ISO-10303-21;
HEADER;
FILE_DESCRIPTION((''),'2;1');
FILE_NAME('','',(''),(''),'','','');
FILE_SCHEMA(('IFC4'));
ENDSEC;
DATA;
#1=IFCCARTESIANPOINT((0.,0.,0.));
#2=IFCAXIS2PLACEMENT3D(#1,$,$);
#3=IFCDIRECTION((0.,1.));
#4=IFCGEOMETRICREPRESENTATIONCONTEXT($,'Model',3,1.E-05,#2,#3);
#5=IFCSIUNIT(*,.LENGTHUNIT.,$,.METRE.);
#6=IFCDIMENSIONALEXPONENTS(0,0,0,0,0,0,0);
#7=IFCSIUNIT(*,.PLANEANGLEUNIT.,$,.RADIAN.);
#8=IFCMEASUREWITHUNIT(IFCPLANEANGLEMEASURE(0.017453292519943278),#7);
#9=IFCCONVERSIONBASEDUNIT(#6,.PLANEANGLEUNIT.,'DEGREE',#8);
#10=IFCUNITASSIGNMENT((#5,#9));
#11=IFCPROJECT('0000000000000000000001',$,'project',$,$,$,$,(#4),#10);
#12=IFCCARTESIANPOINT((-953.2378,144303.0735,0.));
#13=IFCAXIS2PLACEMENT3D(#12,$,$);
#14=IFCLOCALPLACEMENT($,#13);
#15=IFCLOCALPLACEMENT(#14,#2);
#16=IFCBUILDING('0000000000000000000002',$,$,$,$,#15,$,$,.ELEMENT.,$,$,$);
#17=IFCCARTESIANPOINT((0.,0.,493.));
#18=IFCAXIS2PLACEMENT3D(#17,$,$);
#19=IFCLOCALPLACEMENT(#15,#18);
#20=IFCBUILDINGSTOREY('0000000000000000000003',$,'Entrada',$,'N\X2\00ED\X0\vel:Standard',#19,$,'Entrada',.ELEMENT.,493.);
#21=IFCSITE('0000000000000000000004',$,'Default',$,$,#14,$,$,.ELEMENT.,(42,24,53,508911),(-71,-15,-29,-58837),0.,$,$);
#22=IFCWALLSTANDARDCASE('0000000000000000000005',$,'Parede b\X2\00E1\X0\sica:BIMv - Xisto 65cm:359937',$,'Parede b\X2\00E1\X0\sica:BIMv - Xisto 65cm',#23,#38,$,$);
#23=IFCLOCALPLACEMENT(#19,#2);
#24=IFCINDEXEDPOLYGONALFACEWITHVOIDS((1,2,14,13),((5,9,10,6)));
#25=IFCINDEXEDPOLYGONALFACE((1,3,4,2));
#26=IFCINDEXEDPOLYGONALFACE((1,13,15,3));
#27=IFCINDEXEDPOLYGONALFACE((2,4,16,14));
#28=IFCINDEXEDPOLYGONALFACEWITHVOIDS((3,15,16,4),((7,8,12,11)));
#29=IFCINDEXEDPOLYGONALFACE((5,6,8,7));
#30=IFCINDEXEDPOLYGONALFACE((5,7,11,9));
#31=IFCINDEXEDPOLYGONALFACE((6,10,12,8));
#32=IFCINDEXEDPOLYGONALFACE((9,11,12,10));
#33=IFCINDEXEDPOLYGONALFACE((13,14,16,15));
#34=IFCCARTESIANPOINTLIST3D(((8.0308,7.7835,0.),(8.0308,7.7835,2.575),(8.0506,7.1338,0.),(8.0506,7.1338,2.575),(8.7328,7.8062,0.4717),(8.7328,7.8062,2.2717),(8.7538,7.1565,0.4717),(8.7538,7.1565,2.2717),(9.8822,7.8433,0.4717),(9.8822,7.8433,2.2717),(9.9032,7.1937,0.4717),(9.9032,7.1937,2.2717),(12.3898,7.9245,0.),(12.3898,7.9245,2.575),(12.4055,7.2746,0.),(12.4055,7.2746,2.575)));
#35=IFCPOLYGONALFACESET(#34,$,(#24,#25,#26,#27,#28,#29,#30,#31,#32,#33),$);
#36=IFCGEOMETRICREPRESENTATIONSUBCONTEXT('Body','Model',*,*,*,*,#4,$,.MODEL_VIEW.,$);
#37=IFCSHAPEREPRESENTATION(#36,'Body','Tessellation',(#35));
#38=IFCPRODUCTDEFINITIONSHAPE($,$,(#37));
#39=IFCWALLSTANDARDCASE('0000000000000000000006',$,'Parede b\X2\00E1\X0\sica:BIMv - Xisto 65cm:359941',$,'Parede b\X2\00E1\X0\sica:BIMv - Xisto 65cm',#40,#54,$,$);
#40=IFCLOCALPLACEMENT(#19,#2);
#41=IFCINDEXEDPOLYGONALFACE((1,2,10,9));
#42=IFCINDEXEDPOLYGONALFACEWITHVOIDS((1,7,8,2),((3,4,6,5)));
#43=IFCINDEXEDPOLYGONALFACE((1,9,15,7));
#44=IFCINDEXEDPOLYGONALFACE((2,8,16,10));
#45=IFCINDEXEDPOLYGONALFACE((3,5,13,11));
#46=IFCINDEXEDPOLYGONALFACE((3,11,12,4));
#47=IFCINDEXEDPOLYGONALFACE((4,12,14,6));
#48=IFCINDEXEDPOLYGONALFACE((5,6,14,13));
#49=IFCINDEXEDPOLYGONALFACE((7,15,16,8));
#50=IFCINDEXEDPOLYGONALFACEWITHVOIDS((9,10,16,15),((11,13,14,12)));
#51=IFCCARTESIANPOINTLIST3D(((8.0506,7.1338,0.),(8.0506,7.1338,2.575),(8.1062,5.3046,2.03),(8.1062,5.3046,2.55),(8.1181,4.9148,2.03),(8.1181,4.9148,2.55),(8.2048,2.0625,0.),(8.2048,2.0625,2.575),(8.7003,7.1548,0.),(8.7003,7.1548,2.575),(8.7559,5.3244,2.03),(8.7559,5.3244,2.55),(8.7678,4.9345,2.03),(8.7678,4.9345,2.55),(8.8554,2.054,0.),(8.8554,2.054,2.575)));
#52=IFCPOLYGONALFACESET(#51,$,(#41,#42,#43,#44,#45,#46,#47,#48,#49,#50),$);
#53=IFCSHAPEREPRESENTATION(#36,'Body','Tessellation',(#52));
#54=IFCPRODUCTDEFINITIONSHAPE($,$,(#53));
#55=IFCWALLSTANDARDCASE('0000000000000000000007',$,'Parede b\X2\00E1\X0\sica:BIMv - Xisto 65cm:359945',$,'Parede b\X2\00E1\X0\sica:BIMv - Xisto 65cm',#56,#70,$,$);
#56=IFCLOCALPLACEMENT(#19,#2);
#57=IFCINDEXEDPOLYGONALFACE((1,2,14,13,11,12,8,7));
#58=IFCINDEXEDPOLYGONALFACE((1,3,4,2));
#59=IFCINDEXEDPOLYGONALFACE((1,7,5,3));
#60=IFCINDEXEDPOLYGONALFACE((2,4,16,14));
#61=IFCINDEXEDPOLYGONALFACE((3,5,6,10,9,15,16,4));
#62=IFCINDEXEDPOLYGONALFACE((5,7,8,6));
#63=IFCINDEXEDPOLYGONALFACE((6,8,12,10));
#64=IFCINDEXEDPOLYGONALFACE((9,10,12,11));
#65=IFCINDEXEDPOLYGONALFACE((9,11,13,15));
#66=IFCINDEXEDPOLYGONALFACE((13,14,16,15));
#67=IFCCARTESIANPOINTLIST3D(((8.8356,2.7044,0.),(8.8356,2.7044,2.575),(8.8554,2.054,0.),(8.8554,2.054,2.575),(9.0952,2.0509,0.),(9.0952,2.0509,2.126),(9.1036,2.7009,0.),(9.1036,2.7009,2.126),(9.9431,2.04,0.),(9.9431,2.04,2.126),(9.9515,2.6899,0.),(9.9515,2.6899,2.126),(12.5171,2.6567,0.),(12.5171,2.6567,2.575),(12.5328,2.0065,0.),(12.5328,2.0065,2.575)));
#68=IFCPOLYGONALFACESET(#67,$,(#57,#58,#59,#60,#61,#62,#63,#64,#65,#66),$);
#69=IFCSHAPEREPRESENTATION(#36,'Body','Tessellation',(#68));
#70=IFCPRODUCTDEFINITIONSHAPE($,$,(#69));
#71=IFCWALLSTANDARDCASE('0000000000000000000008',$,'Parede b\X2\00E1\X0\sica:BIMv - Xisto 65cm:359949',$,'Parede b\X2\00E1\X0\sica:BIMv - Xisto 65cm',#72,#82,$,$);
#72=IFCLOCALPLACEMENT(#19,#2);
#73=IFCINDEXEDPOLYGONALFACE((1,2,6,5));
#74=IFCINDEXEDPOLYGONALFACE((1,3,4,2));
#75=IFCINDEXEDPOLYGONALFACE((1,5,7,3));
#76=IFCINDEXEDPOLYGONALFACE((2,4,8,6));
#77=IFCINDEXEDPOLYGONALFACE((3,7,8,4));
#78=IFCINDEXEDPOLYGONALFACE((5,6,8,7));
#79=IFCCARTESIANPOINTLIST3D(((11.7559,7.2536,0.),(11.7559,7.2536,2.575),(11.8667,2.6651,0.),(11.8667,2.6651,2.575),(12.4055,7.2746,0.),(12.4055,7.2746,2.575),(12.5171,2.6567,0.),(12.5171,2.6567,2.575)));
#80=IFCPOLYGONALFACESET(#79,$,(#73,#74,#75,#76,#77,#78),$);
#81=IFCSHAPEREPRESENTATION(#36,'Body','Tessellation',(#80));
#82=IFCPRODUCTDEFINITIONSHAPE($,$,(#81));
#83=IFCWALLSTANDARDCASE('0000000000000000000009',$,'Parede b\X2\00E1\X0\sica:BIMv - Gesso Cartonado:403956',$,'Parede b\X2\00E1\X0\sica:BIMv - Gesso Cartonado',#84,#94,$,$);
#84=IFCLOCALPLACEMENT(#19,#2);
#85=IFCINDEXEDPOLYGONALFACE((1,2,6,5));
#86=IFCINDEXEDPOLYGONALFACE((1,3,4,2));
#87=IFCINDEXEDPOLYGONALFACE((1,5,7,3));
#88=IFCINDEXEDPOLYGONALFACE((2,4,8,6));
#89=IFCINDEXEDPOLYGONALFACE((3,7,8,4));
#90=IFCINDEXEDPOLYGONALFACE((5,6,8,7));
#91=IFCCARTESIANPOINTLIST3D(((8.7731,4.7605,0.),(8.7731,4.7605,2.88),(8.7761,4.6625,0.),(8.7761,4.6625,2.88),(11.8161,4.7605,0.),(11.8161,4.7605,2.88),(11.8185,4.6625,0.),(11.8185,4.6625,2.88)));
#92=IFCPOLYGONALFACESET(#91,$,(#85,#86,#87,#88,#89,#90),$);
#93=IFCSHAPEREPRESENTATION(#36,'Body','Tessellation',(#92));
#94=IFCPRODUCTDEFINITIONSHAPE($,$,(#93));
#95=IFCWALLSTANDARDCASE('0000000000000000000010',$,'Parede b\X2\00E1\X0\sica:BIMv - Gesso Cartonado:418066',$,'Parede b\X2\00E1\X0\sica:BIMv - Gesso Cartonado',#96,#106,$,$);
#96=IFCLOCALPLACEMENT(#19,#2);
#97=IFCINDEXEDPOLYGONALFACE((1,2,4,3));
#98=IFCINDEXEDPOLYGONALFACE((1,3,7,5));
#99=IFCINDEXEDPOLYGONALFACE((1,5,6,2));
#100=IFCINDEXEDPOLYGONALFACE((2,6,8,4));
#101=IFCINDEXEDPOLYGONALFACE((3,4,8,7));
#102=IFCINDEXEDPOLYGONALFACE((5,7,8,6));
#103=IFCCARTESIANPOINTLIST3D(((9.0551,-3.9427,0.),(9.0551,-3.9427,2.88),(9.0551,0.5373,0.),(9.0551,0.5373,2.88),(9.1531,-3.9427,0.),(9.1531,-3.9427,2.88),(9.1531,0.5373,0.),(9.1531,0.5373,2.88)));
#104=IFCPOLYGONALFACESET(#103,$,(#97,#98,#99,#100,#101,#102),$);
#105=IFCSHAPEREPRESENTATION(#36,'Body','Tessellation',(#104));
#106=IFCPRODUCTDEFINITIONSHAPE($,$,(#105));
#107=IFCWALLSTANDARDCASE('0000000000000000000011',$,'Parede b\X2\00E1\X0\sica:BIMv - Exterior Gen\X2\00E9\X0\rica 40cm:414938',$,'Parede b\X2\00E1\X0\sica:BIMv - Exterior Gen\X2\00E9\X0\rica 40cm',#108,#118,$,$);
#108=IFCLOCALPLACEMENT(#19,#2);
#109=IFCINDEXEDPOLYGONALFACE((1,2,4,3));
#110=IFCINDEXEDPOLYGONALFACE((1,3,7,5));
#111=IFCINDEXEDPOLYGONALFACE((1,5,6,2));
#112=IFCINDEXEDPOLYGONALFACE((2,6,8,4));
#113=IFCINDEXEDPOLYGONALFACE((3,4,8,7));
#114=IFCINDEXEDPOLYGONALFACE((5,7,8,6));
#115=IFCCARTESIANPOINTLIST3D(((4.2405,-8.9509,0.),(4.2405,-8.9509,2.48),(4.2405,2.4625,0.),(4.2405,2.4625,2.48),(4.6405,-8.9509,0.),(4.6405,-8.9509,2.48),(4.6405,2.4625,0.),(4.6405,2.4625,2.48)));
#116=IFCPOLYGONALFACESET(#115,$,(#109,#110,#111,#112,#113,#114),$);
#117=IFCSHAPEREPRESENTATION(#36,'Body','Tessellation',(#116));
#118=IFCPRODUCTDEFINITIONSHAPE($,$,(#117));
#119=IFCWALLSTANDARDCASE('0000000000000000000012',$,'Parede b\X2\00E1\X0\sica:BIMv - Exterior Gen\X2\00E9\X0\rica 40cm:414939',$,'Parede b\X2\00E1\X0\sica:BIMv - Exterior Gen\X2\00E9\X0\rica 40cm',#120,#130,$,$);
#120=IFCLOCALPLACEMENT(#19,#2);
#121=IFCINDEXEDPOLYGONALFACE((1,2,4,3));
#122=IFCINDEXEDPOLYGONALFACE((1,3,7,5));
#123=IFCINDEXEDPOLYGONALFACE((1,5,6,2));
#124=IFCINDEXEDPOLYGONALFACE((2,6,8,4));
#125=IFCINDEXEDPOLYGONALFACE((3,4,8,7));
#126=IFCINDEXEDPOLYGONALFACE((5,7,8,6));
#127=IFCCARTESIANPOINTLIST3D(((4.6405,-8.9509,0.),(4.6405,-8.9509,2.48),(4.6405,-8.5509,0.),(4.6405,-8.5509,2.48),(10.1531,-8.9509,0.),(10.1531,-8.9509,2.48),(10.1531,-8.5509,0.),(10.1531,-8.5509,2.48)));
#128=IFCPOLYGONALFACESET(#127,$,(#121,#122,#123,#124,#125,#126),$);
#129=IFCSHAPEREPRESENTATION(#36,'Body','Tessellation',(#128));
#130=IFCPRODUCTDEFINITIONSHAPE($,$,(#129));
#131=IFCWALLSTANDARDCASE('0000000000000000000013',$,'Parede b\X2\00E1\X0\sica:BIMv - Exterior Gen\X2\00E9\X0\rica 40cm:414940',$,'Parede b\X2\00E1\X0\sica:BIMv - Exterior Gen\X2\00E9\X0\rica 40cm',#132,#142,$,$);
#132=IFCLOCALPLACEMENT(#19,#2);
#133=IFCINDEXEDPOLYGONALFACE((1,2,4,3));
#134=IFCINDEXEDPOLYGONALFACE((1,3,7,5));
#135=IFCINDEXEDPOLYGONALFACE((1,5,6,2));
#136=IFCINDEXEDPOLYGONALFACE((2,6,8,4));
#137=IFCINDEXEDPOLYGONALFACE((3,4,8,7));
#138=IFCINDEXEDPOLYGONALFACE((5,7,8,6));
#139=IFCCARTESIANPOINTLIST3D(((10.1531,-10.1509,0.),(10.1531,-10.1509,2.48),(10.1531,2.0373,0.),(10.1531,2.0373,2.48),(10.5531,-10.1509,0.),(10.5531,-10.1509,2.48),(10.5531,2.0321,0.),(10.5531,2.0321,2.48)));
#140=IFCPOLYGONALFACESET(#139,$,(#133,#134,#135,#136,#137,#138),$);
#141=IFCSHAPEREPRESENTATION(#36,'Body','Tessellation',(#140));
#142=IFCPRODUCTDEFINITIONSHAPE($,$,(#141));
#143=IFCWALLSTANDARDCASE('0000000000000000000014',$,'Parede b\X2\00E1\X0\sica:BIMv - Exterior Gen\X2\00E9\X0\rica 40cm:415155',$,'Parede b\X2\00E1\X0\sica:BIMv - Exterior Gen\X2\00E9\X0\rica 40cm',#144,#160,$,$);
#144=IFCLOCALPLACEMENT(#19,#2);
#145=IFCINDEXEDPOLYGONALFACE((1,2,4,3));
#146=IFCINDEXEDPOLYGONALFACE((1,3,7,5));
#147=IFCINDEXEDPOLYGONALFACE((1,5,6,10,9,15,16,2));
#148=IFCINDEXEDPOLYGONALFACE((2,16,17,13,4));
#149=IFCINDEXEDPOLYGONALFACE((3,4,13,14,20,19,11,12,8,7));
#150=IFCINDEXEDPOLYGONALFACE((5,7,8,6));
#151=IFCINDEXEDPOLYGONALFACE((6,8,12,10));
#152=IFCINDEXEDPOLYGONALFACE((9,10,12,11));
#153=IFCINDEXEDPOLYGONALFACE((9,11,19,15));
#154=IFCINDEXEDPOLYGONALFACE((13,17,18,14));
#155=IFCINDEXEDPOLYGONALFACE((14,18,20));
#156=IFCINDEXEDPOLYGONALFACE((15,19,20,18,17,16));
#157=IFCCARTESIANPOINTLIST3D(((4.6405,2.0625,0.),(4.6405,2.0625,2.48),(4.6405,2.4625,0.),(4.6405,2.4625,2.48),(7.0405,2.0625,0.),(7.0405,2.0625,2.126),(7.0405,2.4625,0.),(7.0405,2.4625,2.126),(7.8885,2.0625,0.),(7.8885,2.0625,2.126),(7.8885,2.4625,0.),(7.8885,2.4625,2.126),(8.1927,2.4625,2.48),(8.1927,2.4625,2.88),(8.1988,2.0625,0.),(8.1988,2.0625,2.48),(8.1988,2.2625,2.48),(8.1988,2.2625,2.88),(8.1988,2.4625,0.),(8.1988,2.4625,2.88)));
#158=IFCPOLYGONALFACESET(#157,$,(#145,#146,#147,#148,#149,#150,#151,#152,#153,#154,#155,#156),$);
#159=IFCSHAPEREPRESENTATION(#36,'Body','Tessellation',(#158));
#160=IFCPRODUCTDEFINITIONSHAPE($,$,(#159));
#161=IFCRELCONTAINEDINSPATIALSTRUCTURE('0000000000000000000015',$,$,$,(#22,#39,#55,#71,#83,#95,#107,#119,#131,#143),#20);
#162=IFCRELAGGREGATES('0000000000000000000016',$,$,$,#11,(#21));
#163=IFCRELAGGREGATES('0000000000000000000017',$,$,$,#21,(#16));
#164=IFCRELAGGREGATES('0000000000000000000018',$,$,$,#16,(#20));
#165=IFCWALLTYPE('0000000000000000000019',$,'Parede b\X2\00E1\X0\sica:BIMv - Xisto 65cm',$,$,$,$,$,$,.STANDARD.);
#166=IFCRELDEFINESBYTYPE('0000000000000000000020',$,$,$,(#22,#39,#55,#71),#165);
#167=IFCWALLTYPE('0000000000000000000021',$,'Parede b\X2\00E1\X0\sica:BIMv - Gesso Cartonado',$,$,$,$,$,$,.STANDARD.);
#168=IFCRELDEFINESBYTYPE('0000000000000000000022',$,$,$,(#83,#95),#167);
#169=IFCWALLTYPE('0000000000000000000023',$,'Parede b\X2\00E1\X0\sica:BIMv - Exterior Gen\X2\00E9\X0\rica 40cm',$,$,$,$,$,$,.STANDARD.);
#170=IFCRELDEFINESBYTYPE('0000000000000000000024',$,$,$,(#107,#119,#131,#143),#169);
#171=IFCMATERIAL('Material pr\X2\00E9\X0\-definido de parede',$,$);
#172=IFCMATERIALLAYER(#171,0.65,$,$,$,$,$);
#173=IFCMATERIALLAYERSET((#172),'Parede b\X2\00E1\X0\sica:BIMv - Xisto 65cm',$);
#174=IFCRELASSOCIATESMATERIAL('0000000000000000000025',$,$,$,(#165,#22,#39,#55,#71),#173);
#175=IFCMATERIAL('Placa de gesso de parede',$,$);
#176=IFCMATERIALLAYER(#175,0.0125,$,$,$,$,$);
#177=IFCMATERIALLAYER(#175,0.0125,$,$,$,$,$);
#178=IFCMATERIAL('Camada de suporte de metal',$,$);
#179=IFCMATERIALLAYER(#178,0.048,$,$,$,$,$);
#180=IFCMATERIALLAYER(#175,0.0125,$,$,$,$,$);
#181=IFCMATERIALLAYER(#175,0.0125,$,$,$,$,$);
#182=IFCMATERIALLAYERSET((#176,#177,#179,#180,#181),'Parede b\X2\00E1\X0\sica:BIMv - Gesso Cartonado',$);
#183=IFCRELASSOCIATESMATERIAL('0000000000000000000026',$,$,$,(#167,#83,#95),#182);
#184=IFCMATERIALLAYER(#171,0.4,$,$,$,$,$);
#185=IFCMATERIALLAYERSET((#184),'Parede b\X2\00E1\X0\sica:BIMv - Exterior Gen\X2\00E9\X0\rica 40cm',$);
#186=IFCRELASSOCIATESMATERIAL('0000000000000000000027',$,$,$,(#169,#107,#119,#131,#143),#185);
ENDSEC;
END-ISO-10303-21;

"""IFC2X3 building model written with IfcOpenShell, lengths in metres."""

from ifc_helpers import new_model, entity, si_unit, converted_unit, direction, frame, frame_2d, origin, place, context, subcontext, project, spatial, polyline, rectangle, outline, extrude, clip, bounded_halfspace, material, layer, layer_set, layer_usage, type_object, element, save


model = new_model("IFC2X3")

# Units and contexts
model_context = context("Model", 3, precision=1e-05, world=origin(), true_north=direction((0.0, 1.0)))
body_context = subcontext(model_context, "Body", "Model", "MODEL_VIEW")
ifc_project = project(units=[si_unit("LENGTHUNIT", "METRE"), converted_unit("PLANEANGLEUNIT", "DEGREE", entity("IfcPlaneAngleMeasure", 0.017453292519943278), si_unit("PLANEANGLEUNIT", "RADIAN"), dimensions=[0, 0, 0, 0, 0, 0, 0])], contexts=[model_context])

# Site, building, storey
site_placement = place(None, frame((-953.2378, 144303.0735, 0.0)))
site = spatial("IfcSite", under=ifc_project, at=site_placement, Name="Default", CompositionType="ELEMENT", RefLatitude=(42, 24, 53, 508911), RefLongitude=(-71, -15, -29, -58837), RefElevation=0.0)
building_placement = place(site_placement, origin())
building = spatial("IfcBuilding", under=site, at=building_placement, CompositionType="ELEMENT")
storey_placement = place(building_placement, frame((0.0, 0.0, 493.0)))
storey = spatial("IfcBuildingStorey", under=building, at=storey_placement, Name="Entrada", ObjectType="Nível:Standard", LongName="Entrada", CompositionType="ELEMENT", Elevation=493.0)

# Walls, openings
ifc_material_1 = material(Name="Material pré-definido de parede")
ifc_layer_1 = layer(ifc_material_1, 0.65)
ifc_layer_set_1 = layer_set([ifc_layer_1], Name="Parede básica:BIMv - Xisto 65cm")
ifc_layer_usage_1 = layer_usage(ifc_layer_set_1, "AXIS2", "NEGATIVE", 0.325)
wall_type_1 = type_object("IfcWallType", Name="Parede básica:BIMv - Xisto 65cm", PredefinedType="STANDARD", material=ifc_layer_set_1)
wall_1_placement = place(storey_placement, frame((8.0401, 7.4586, 0.0), z_axis=(0.0, 0.0, 1.0), x_axis=(0.999477, 0.03233, 0.0)))
wall_1 = element("IfcWallStandardCase", 1, at=wall_1_placement, inside=storey, type_object=wall_type_1, material=ifc_layer_usage_1, Name="Parede básica:BIMv - Xisto 65cm:359937", ObjectType="Parede básica:BIMv - Xisto 65cm", context=body_context, shape_type="SweptSolid", body=[
    extrude(outline(polyline([(4.3572, -0.325), (4.3625, 0.325), (0.0013, 0.325), (0.0, -0.325), (0.65, -0.325), (3.7072, -0.325), (4.3572, -0.325)])), origin(), (0.0, 0.0, 1.0), 2.575),
])
opening_1_placement = place(wall_1_placement, frame((-8.277, -7.1948, 0.0), z_axis=(0.0, 0.0, 1.0), x_axis=(0.999477, -0.03233, 0.0)))
element("IfcOpeningElement", 2, at=opening_1_placement, cuts=wall_1, ObjectType="Opening", context=body_context, shape_type="SweptSolid", body=[
    extrude(rectangle(XDim=1.8, YDim=1.15, at=frame_2d((0.0, 0.0), x_axis=(0.0, 1.0))), frame((9.3778, 5.6519, 1.3717), z_axis=(-0.03233, 0.999477, 0.0), x_axis=(-0.999477, -0.03233, 0.0)), (0.0, 0.0, 1.0), 3.048),
])
ifc_layer_usage_2 = layer_usage(ifc_layer_set_1, "AXIS2", "NEGATIVE", 0.325)
wall_2_placement = place(storey_placement, frame((8.5305, 2.0442, 0.0), z_axis=(0.0, 0.0, 1.0), x_axis=(-0.030399, 0.999538, 0.0)))
wall_2 = element("IfcWallStandardCase", 3, at=wall_2_placement, inside=storey, type_object=wall_type_1, material=ifc_layer_usage_2, Name="Parede básica:BIMv - Xisto 65cm:359941", ObjectType="Parede básica:BIMv - Xisto 65cm", context=body_context, shape_type="SweptSolid", body=[
    extrude(outline(polyline([(5.1031, -0.325), (5.1018, 0.325), (0.0282, 0.325), (0.0, -0.325), (0.6506, -0.325), (5.1031, -0.325)])), origin(), (0.0, 0.0, 1.0), 2.575),
])
opening_2_placement = place(wall_2_placement, frame((-1.7839, 8.5887, 0.0), z_axis=(0.0, 0.0, 1.0), x_axis=(-0.030399, -0.999538, 0.0)))
element("IfcOpeningElement", 4, at=opening_2_placement, cuts=wall_2, ObjectType="Opening", context=body_context, shape_type="SweptSolid", body=[
    extrude(rectangle(XDim=0.52, YDim=0.39, at=frame_2d((0.0, 0.0), x_axis=(1.0, 0.0))), frame((10.2852, 5.1758, 2.29), z_axis=(-0.999538, -0.030399, 0.0), x_axis=(0.0, 0.0, 1.0)), (0.0, 0.0, 1.0), 3.048),
])
ifc_layer_usage_3 = layer_usage(ifc_layer_set_1, "AXIS2", "NEGATIVE", 0.325)
wall_3_placement = place(storey_placement, frame((12.537, 2.3314, 0.0), z_axis=(0.0, 0.0, 1.0), x_axis=(-0.999916, 0.012938, 0.0)))
wall_3 = element("IfcWallStandardCase", 5, at=wall_3_placement, inside=storey, type_object=wall_type_1, material=ifc_layer_usage_3, Name="Parede básica:BIMv - Xisto 65cm:359945", ObjectType="Parede básica:BIMv - Xisto 65cm", context=body_context, shape_type="SweptSolid", body=[
    extrude(outline(polyline([(0.0241, -0.325), (0.6746, -0.325), (2.2584, -0.325), (3.7059, -0.325), (3.6778, 0.325), (2.2584, 0.325), (0.0, 0.325), (0.0241, -0.325)])), origin(), (0.0, 0.0, 1.0), 2.575),
])
opening_3_placement = place(wall_3_placement, frame((3.4379, 0.325, 0.0)))
element("IfcOpeningElement", 6, at=opening_3_placement, cuts=wall_3, ObjectType="Opening", context=body_context, shape_type="SweptSolid", body=[
    extrude(rectangle(XDim=2.126, YDim=0.848, at=frame_2d((1.063, 0.424), x_axis=(1.0, 0.0))), frame((0.0, 0.0, 0.0), z_axis=(0.0, -1.0, 0.0), x_axis=(0.0, 0.0, 1.0)), (0.0, 0.0, 1.0), 0.65),
])

# Walls
ifc_layer_usage_4 = layer_usage(ifc_layer_set_1, "AXIS2", "NEGATIVE", 0.325)
wall_4_placement = place(storey_placement, frame((12.0806, 7.2668, 0.0), z_axis=(0.0, 0.0, 1.0), x_axis=(0.024156, -0.999708, 0.0)))
element("IfcWallStandardCase", 7, at=wall_4_placement, inside=storey, type_object=wall_type_1, material=ifc_layer_usage_4, Name="Parede básica:BIMv - Xisto 65cm:359949", ObjectType="Parede básica:BIMv - Xisto 65cm", context=body_context, shape_type="SweptSolid", body=[
    extrude(outline(polyline([(4.5951, -0.325), (4.6193, 0.325), (0.0, 0.325), (0.0053, -0.325), (4.5951, -0.325)])), origin(), (0.0, 0.0, 1.0), 2.575),
])
ifc_material_2 = material(Name="Placa de gesso de parede")
ifc_layer_2 = layer(ifc_material_2, 0.0125)
ifc_layer_3 = layer(ifc_material_2, 0.0125)
ifc_material_3 = material(Name="Camada de suporte de metal")
ifc_layer_4 = layer(ifc_material_3, 0.048)
ifc_layer_5 = layer(ifc_material_2, 0.0125)
ifc_layer_6 = layer(ifc_material_2, 0.0125)
ifc_layer_set_2 = layer_set([ifc_layer_2, ifc_layer_3, ifc_layer_4, ifc_layer_5, ifc_layer_6], Name="Parede básica:BIMv - Gesso Cartonado")
ifc_layer_usage_5 = layer_usage(ifc_layer_set_2, "AXIS2", "NEGATIVE", 0.049)
wall_type_2 = type_object("IfcWallType", Name="Parede básica:BIMv - Gesso Cartonado", PredefinedType="STANDARD", material=ifc_layer_set_2)
wall_5_placement = place(storey_placement, frame((8.7731, 4.7115, 0.0)))
element("IfcWallStandardCase", 8, at=wall_5_placement, inside=storey, type_object=wall_type_2, material=ifc_layer_usage_5, Name="Parede básica:BIMv - Gesso Cartonado:403956", ObjectType="Parede básica:BIMv - Gesso Cartonado", context=body_context, shape_type="SweptSolid", body=[
    extrude(outline(polyline([(3.0454, -0.049), (3.043, 0.049), (0.0, 0.049), (0.003, -0.049), (3.0454, -0.049)])), origin(), (0.0, 0.0, 1.0), 2.88),
])
ifc_layer_usage_6 = layer_usage(ifc_layer_set_2, "AXIS2", "NEGATIVE", 0.049)
wall_6_placement = place(storey_placement, frame((9.1041, -3.9427, 0.0), z_axis=(0.0, 0.0, 1.0), x_axis=(0.0, 1.0, 0.0)))
element("IfcWallStandardCase", 9, at=wall_6_placement, inside=storey, type_object=wall_type_2, material=ifc_layer_usage_6, Name="Parede básica:BIMv - Gesso Cartonado:418066", ObjectType="Parede básica:BIMv - Gesso Cartonado", context=body_context, shape_type="SweptSolid", body=[
    extrude(rectangle(XDim=4.48, YDim=0.098, at=frame_2d((2.24, 0.0), x_axis=(-1.0, 0.0))), origin(), (0.0, 0.0, 1.0), 2.88),
])
ifc_layer_7 = layer(ifc_material_1, 0.4)
ifc_layer_set_3 = layer_set([ifc_layer_7], Name="Parede básica:BIMv - Exterior Genérica 40cm")
ifc_layer_usage_7 = layer_usage(ifc_layer_set_3, "AXIS2", "NEGATIVE", 0.2)
wall_type_3 = type_object("IfcWallType", Name="Parede básica:BIMv - Exterior Genérica 40cm", PredefinedType="STANDARD", material=ifc_layer_set_3)
wall_7_placement = place(storey_placement, frame((4.4405, 2.4625, 0.0), z_axis=(0.0, 0.0, 1.0), x_axis=(0.0, -1.0, 0.0)))
element("IfcWallStandardCase", 10, at=wall_7_placement, inside=storey, type_object=wall_type_3, material=ifc_layer_usage_7, Name="Parede básica:BIMv - Exterior Genérica 40cm:414938", ObjectType="Parede básica:BIMv - Exterior Genérica 40cm", context=body_context, shape_type="Clipping", body=[
    clip(extrude(rectangle(XDim=11.4134, YDim=0.4, at=frame_2d((5.7067, 0.0), x_axis=(-1.0, 0.0))), origin(), (0.0, 0.0, 1.0), 2.48), bounded_halfspace(frame((0.0, -0.2, 2.48), z_axis=(0.0, 0.0, -1.0), x_axis=(0.999538, 0.030399, 0.0)), True, frame((0.0, -0.2, 2.48)), polyline([(0.0, 0.0), (11.4134, 0.0), (11.4134, 0.4), (11.0134, 0.4), (0.4, 0.4), (0.0, 0.4), (0.0, 0.0)]))),
])
ifc_layer_usage_8 = layer_usage(ifc_layer_set_3, "AXIS2", "NEGATIVE", 0.2)
wall_8_placement = place(storey_placement, frame((4.6405, -8.7509, 0.0)))
element("IfcWallStandardCase", 11, at=wall_8_placement, inside=storey, type_object=wall_type_3, material=ifc_layer_usage_8, Name="Parede básica:BIMv - Exterior Genérica 40cm:414939", ObjectType="Parede básica:BIMv - Exterior Genérica 40cm", context=body_context, shape_type="Clipping", body=[
    clip(extrude(rectangle(XDim=5.5127, YDim=0.4, at=frame_2d((2.7563, 0.0), x_axis=(-1.0, 0.0))), origin(), (0.0, 0.0, 1.0), 2.48), bounded_halfspace(frame((0.0, -0.2, 2.48), z_axis=(0.0, 0.0, -1.0), x_axis=(0.030399, -0.999538, 0.0)), True, frame((0.0, -0.2, 2.48)), polyline([(0.0, 0.0), (5.5127, 0.0), (5.5127, 0.4), (0.0, 0.4), (0.0, 0.0)]))),
])
ifc_layer_usage_9 = layer_usage(ifc_layer_set_3, "AXIS2", "POSITIVE", -0.2)
wall_9_placement = place(storey_placement, frame((10.3531, -10.1509, 0.0), z_axis=(0.0, 0.0, 1.0), x_axis=(0.0, 1.0, 0.0)))
element("IfcWallStandardCase", 12, at=wall_9_placement, inside=storey, type_object=wall_type_3, material=ifc_layer_usage_9, Name="Parede básica:BIMv - Exterior Genérica 40cm:414940", ObjectType="Parede básica:BIMv - Exterior Genérica 40cm", context=body_context, shape_type="Clipping", body=[
    clip(extrude(outline(polyline([(12.183, -0.2), (12.1882, 0.2), (1.6, 0.2), (1.2, 0.2), (0.0, 0.2), (0.0, -0.2), (12.183, -0.2)])), origin(), (0.0, 0.0, 1.0), 2.48), bounded_halfspace(frame((0.0, -0.2, 2.48), z_axis=(0.0, 0.0, -1.0), x_axis=(-0.999538, -0.030399, 0.0)), True, frame((0.0, -0.2, 2.48)), polyline([(0.0, 0.0), (12.183, 0.0), (12.1882, 0.4), (10.6882, 0.4), (6.2082, 0.4), (1.6, 0.4), (1.2, 0.4), (0.0, 0.4), (0.0, 0.0)]))),
])

# Wall, opening
ifc_layer_usage_10 = layer_usage(ifc_layer_set_3, "AXIS2", "POSITIVE", -0.2)
wall_10_placement = place(storey_placement, frame((8.1988, 2.2625, 0.0), z_axis=(0.0, 0.0, 1.0), x_axis=(-1.0, 0.0, 0.0)))
wall_10 = element("IfcWallStandardCase", 13, at=wall_10_placement, inside=storey, type_object=wall_type_3, material=ifc_layer_usage_10, Name="Parede básica:BIMv - Exterior Genérica 40cm:415155", ObjectType="Parede básica:BIMv - Exterior Genérica 40cm", context=body_context, shape_type="Clipping", body=[
    clip(extrude(rectangle(XDim=3.5583, YDim=0.4, at=frame_2d((1.7791, 0.0), x_axis=(-1.0, 0.0))), origin(), (0.0, 0.0, 1.0), 2.88), bounded_halfspace(frame((0.0061, -0.2, 2.48), z_axis=(0.0, 0.0, -1.0), x_axis=(-0.030399, 0.999538, 0.0)), True, frame((0.0061, -0.2, 2.48)), polyline([(0.0, 0.0), (3.5522, 0.0), (3.5522, 0.4), (-0.0061, 0.4), (-0.0061, 0.2), (0.0, 0.0)]))),
])
opening_4_placement = place(wall_10_placement, frame((0.3103, -0.2, 0.0)))
element("IfcOpeningElement", 14, at=opening_4_placement, cuts=wall_10, ObjectType="Opening", context=body_context, shape_type="SweptSolid", body=[
    extrude(rectangle(XDim=2.126, YDim=0.848, at=frame_2d((1.063, 0.424), x_axis=(1.0, 0.0))), frame((0.0, 0.0, 0.0), z_axis=(0.0, 1.0, 0.0), x_axis=(0.0, 0.0, 1.0)), (0.0, 0.0, 1.0), 0.4),
])

save(model, "model.ifc")
